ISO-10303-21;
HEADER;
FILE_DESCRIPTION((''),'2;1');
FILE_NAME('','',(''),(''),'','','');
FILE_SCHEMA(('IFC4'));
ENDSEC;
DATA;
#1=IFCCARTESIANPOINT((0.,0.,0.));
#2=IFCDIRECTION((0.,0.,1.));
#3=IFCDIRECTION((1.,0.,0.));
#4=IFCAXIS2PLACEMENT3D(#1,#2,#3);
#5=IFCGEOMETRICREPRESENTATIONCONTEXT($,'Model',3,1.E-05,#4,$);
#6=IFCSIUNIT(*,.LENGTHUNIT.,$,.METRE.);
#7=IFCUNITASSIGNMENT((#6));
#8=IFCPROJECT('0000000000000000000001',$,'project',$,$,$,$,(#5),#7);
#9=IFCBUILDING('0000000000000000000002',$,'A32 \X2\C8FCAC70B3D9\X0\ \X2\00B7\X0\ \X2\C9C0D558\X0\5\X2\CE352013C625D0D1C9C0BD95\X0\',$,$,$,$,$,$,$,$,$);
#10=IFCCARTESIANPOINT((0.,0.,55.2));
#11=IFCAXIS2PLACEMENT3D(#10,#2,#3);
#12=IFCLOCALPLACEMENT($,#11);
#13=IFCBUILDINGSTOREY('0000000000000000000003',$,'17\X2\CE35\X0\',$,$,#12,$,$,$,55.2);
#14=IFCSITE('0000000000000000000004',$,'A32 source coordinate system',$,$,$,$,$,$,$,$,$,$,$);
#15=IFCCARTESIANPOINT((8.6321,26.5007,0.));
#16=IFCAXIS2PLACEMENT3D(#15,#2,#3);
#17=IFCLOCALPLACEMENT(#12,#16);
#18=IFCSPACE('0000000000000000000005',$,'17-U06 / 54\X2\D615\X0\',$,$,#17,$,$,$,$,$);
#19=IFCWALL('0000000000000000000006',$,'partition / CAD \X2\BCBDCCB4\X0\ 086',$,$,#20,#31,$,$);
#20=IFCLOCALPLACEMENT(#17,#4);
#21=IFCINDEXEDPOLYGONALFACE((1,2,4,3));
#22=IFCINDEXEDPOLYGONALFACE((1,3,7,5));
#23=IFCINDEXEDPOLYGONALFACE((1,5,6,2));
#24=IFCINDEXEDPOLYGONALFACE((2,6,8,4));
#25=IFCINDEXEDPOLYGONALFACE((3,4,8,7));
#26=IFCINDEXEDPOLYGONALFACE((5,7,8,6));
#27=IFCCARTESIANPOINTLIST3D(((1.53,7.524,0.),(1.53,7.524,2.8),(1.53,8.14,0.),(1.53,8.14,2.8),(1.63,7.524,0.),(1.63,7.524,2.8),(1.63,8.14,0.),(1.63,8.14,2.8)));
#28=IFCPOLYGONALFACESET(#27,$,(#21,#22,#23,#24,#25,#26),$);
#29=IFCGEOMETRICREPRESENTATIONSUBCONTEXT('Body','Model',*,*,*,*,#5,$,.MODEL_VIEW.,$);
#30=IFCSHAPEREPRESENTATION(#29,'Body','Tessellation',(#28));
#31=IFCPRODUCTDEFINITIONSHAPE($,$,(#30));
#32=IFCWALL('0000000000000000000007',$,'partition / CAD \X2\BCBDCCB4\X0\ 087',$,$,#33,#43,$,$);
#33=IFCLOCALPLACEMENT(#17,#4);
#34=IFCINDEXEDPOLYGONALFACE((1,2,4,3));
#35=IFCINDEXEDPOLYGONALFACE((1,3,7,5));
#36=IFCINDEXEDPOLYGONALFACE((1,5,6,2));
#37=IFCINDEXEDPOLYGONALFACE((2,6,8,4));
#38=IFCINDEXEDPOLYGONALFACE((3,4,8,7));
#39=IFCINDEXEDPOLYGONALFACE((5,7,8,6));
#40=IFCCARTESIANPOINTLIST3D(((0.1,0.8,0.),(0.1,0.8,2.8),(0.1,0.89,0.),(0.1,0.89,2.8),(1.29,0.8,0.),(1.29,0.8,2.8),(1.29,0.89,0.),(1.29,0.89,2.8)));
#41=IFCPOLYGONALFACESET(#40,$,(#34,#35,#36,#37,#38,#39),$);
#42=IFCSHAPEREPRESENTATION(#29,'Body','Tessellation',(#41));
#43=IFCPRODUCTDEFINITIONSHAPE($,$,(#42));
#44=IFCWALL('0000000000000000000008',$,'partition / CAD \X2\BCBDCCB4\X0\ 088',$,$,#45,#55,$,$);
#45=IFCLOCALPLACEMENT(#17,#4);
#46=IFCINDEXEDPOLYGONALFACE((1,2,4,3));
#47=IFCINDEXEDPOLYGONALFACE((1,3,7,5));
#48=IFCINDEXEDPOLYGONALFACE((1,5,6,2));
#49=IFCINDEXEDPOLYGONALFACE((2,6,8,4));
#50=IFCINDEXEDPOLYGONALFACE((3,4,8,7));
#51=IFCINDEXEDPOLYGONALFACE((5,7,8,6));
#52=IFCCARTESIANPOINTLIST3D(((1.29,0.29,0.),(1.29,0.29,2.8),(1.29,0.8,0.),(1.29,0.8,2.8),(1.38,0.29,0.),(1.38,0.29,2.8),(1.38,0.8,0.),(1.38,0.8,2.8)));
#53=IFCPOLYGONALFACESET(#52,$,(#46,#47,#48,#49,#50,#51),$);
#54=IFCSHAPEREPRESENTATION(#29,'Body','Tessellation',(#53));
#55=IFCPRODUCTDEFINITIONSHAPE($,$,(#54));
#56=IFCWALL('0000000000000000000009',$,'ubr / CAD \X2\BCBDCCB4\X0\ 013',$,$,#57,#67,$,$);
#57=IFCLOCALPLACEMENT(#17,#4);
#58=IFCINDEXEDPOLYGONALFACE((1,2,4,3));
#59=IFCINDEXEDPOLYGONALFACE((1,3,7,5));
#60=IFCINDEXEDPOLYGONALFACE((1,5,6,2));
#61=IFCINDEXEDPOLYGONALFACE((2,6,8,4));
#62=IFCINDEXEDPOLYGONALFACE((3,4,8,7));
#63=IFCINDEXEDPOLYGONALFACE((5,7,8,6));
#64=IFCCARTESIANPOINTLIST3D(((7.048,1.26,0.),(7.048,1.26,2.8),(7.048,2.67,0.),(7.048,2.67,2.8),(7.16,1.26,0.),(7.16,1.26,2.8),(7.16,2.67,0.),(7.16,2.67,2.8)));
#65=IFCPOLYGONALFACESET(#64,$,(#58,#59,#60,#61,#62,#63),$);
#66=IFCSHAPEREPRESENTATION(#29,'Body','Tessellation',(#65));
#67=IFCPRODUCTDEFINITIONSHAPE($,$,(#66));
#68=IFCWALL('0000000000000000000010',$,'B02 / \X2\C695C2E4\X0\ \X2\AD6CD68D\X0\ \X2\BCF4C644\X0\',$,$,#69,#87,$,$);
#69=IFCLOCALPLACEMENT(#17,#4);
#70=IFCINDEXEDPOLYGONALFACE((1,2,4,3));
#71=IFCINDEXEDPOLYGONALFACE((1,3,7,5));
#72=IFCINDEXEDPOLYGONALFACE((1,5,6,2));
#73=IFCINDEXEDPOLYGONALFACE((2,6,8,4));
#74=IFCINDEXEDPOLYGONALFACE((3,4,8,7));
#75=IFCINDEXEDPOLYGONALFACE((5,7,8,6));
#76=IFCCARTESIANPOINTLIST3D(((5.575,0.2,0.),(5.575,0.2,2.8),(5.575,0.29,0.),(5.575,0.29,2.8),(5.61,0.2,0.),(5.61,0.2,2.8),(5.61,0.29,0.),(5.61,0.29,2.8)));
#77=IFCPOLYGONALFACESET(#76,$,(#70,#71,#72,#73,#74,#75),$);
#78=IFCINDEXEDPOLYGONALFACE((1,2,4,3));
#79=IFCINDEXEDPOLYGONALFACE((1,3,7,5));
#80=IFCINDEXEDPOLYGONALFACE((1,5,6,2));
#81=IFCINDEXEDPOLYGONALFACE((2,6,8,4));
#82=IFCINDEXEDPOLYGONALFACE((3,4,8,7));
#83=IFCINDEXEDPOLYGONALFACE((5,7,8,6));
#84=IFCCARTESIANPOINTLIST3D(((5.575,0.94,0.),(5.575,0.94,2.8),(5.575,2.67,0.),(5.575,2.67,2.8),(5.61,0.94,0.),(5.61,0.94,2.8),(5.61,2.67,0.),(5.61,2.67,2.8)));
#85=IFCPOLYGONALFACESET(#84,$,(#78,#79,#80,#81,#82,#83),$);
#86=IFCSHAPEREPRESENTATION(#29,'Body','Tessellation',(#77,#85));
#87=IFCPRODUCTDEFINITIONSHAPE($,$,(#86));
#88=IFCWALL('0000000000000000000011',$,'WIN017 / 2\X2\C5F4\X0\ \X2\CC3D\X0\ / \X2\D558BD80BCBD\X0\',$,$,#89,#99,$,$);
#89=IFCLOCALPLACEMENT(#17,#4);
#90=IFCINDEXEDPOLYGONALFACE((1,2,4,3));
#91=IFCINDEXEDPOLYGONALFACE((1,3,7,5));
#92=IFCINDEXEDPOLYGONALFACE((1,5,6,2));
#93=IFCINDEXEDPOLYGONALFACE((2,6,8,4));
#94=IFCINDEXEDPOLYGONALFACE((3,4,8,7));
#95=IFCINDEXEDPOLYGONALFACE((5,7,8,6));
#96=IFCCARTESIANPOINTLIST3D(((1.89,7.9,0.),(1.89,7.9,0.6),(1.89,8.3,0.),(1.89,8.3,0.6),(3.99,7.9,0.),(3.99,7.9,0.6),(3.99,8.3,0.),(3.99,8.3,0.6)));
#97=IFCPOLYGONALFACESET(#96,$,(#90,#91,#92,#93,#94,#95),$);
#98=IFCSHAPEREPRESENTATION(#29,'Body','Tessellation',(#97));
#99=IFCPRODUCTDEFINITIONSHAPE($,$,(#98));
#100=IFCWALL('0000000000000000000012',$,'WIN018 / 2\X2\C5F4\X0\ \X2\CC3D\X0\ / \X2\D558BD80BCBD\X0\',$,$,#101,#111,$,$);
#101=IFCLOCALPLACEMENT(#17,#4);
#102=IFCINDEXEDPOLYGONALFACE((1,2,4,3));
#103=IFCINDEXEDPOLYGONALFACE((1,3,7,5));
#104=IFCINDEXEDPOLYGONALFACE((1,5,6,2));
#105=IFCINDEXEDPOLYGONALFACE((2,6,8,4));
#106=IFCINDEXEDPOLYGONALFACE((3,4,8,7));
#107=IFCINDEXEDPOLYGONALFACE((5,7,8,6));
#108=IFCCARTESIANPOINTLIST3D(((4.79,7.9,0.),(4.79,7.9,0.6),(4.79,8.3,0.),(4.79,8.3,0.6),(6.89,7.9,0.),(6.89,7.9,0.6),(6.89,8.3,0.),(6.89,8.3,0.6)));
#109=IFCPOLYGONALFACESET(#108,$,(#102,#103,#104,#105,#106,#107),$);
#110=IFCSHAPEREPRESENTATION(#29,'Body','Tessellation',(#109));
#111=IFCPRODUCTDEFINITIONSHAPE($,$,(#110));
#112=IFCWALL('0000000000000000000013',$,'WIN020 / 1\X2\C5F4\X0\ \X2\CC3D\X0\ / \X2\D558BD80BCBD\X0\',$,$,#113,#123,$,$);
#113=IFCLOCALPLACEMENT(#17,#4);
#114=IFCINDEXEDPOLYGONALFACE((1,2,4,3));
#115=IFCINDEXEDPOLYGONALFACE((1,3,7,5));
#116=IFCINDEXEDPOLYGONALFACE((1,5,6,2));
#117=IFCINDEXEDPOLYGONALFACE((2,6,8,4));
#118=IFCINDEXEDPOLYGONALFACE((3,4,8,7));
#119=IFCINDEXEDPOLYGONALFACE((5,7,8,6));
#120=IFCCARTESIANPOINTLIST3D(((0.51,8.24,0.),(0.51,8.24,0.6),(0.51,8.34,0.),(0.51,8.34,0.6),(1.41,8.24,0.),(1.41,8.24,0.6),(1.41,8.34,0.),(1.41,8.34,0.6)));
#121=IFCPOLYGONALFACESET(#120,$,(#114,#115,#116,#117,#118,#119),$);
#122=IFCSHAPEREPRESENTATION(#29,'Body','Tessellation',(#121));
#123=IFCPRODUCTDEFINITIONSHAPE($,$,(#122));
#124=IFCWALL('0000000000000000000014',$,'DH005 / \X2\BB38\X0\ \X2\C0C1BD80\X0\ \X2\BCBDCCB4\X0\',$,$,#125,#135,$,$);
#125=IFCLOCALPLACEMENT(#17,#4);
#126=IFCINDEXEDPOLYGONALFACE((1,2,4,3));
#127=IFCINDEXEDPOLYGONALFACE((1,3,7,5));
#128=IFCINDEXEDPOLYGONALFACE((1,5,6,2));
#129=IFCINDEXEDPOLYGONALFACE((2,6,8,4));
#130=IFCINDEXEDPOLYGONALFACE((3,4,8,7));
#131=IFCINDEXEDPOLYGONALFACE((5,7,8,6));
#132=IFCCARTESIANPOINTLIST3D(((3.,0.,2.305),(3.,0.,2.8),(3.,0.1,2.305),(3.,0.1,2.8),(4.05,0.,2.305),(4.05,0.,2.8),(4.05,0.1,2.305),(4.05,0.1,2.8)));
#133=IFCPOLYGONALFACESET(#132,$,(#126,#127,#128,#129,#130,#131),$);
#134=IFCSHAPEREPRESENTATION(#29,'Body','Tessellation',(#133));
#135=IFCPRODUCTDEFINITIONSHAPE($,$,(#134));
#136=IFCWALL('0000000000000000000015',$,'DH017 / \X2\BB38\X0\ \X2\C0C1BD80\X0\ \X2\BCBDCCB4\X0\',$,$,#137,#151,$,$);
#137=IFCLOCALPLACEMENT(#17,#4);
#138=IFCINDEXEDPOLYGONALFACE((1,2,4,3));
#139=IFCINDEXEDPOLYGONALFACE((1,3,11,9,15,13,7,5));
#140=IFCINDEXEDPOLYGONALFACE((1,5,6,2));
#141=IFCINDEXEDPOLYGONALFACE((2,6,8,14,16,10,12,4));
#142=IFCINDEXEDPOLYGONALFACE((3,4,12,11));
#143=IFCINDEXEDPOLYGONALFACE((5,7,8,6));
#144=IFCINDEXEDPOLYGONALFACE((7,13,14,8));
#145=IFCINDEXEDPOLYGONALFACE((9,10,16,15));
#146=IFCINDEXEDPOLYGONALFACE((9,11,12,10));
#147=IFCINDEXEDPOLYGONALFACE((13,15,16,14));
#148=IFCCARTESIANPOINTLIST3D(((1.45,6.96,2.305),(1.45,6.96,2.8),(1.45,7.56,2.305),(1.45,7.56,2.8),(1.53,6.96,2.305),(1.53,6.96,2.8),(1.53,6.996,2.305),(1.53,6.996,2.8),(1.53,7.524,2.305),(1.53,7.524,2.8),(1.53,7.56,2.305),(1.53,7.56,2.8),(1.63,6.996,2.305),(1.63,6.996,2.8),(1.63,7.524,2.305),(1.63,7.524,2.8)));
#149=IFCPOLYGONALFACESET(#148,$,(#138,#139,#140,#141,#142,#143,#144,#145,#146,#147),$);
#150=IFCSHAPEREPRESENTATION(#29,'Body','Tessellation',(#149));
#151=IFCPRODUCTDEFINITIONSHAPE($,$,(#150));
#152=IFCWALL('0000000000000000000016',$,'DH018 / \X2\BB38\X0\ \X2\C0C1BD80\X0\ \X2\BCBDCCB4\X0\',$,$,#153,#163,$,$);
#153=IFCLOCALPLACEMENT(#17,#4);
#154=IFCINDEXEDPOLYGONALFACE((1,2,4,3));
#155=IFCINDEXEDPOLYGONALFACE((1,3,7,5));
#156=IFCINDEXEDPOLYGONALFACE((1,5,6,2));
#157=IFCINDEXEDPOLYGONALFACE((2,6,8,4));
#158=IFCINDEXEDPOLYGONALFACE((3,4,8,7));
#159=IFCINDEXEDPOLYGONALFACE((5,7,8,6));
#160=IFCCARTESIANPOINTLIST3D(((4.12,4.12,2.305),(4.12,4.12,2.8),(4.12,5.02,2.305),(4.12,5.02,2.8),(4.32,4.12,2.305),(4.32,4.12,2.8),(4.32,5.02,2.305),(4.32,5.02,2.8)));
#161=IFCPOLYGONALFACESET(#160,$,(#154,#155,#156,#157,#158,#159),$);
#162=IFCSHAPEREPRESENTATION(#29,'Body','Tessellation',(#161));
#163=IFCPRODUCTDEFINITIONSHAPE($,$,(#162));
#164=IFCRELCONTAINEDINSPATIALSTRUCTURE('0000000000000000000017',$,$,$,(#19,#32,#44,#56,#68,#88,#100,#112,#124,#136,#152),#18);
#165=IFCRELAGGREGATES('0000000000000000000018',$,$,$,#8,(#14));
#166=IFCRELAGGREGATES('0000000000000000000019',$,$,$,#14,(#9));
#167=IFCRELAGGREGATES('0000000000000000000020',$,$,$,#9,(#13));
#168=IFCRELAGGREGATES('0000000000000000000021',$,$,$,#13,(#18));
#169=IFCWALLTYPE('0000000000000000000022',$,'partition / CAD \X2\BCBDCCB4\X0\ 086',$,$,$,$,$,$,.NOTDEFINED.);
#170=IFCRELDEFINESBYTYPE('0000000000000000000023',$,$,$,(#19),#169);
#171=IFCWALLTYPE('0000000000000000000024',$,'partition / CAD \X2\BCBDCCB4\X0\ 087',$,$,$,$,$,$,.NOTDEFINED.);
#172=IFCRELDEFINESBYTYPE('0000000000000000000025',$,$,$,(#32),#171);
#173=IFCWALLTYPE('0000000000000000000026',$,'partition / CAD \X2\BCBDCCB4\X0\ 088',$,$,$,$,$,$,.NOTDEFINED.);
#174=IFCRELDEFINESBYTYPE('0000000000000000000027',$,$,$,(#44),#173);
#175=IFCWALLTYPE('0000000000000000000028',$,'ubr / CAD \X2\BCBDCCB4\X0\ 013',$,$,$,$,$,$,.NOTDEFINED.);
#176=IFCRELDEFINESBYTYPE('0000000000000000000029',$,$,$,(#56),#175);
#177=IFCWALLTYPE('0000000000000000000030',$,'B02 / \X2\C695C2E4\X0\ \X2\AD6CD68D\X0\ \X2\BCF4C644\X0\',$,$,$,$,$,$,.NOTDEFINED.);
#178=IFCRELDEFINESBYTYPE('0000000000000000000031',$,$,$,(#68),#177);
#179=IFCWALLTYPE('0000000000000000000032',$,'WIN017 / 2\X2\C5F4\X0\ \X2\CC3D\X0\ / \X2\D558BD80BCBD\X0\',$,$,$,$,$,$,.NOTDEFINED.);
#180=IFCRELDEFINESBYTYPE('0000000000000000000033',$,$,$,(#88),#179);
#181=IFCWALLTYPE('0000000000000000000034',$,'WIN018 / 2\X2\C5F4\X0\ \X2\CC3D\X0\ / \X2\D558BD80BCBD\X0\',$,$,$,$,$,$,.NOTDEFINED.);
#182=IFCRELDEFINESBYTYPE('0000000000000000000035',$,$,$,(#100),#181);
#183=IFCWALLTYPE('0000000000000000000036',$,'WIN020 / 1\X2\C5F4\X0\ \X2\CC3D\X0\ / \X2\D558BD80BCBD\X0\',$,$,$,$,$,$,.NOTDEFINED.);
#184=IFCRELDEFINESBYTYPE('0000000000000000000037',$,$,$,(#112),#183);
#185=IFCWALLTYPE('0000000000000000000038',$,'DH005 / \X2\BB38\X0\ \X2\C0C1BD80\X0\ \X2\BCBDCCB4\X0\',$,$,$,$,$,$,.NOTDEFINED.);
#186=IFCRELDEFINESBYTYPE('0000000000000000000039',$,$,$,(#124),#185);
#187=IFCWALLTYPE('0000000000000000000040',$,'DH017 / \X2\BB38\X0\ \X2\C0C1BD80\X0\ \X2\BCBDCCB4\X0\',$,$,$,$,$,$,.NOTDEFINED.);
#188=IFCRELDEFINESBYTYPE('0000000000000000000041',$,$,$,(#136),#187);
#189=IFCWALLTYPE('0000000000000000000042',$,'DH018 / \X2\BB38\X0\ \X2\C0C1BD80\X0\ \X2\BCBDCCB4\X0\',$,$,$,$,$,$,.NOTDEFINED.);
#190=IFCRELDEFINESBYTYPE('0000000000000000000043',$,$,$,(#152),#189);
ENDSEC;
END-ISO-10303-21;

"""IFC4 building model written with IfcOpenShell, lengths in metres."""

from ifc_helpers import new_model, si_unit, frame, origin, origin_with_axes, place, context, subcontext, project, spatial, polyline, outline, extrude, source, transform, mapped, type_object, type_shapes, element, save


model = new_model("IFC4")

# Units and contexts
model_context = context("Model", 3, precision=1e-05, world=origin_with_axes())
body_context = subcontext(model_context, "Body", "Model", "MODEL_VIEW")
ifc_project = project(units=[si_unit("LENGTHUNIT", "METRE")], contexts=[model_context])

# Site, building, storey, space
site = spatial("IfcSite", under=ifc_project, Name="A32 source coordinate system")
building = spatial("IfcBuilding", under=site, Name="A32 주거동 · 지하5층–옥탑지붕")
storey_placement = place(None, frame((0.0, 0.0, 55.2), z_axis=(0.0, 0.0, 1.0), x_axis=(1.0, 0.0, 0.0)))
storey = spatial("IfcBuildingStorey", under=building, at=storey_placement, Name="17층", Elevation=55.2)
space_placement = place(storey_placement, frame((8.6321, 26.5007, 0.0), z_axis=(0.0, 0.0, 1.0), x_axis=(1.0, 0.0, 0.0)))
space = spatial("IfcSpace", under=storey, at=space_placement, Name="17-U06 / 54형")

# Walls
wall_type_1 = type_object("IfcWallType", Name="partition / CAD 벽체 086", PredefinedType="NOTDEFINED")
shared_shape_1 = source(origin(), body_context, "Body", "SweptSolid", [
    extrude(outline(polyline([(1.53, 7.524), (1.53, 8.14), (1.63, 8.14), (1.63, 7.524), (1.53, 7.524)])), origin(), (0.0, 0.0, 1.0), 2.8),
])
type_shapes(wall_type_1, [shared_shape_1])
wall_1_placement = place(space_placement, origin_with_axes())
element("IfcWall", 1, at=wall_1_placement, inside=space, type_object=wall_type_1, Name="partition / CAD 벽체 086", context=body_context, shape_type="MappedRepresentation", body=[
    mapped(shared_shape_1, transform((0.0, 0.0, 0.0), scale=1.0)),
])
wall_type_2 = type_object("IfcWallType", Name="partition / CAD 벽체 087", PredefinedType="NOTDEFINED")
shared_shape_2 = source(origin(), body_context, "Body", "SweptSolid", [
    extrude(outline(polyline([(1.29, 0.8), (0.1, 0.8), (0.1, 0.89), (1.29, 0.89), (1.29, 0.8)])), origin(), (0.0, 0.0, 1.0), 2.8),
])
type_shapes(wall_type_2, [shared_shape_2])
wall_2_placement = place(space_placement, origin_with_axes())
element("IfcWall", 2, at=wall_2_placement, inside=space, type_object=wall_type_2, Name="partition / CAD 벽체 087", context=body_context, shape_type="MappedRepresentation", body=[
    mapped(shared_shape_2, transform((0.0, 0.0, 0.0), scale=1.0)),
])
wall_type_3 = type_object("IfcWallType", Name="partition / CAD 벽체 088", PredefinedType="NOTDEFINED")
shared_shape_3 = source(origin(), body_context, "Body", "SweptSolid", [
    extrude(outline(polyline([(1.29, 0.29), (1.29, 0.8), (1.38, 0.8), (1.38, 0.29), (1.29, 0.29)])), origin(), (0.0, 0.0, 1.0), 2.8),
])
type_shapes(wall_type_3, [shared_shape_3])
wall_3_placement = place(space_placement, origin_with_axes())
element("IfcWall", 3, at=wall_3_placement, inside=space, type_object=wall_type_3, Name="partition / CAD 벽체 088", context=body_context, shape_type="MappedRepresentation", body=[
    mapped(shared_shape_3, transform((0.0, 0.0, 0.0), scale=1.0)),
])
wall_type_4 = type_object("IfcWallType", Name="ubr / CAD 벽체 013", PredefinedType="NOTDEFINED")
shared_shape_4 = source(origin(), body_context, "Body", "SweptSolid", [
    extrude(outline(polyline([(7.16, 1.26), (7.048, 1.26), (7.048, 2.67), (7.16, 2.67), (7.16, 1.26)])), origin(), (0.0, 0.0, 1.0), 2.8),
])
type_shapes(wall_type_4, [shared_shape_4])
wall_4_placement = place(space_placement, origin_with_axes())
element("IfcWall", 4, at=wall_4_placement, inside=space, type_object=wall_type_4, Name="ubr / CAD 벽체 013", context=body_context, shape_type="MappedRepresentation", body=[
    mapped(shared_shape_4, transform((0.0, 0.0, 0.0), scale=1.0)),
])
wall_type_5 = type_object("IfcWallType", Name="B02 / 욕실 구획 보완", PredefinedType="NOTDEFINED")
shared_shape_5 = source(origin(), body_context, "Body", "SweptSolid", [
    extrude(outline(polyline([(5.575, 0.2), (5.575, 0.29), (5.61, 0.29), (5.61, 0.2), (5.575, 0.2)])), origin(), (0.0, 0.0, 1.0), 2.8),
    extrude(outline(polyline([(5.575, 0.94), (5.575, 2.67), (5.61, 2.67), (5.61, 0.94), (5.575, 0.94)])), origin(), (0.0, 0.0, 1.0), 2.8),
])
type_shapes(wall_type_5, [shared_shape_5])
wall_5_placement = place(space_placement, origin_with_axes())
element("IfcWall", 5, at=wall_5_placement, inside=space, type_object=wall_type_5, Name="B02 / 욕실 구획 보완", context=body_context, shape_type="MappedRepresentation", body=[
    mapped(shared_shape_5, transform((0.0, 0.0, 0.0), scale=1.0)),
])
wall_type_6 = type_object("IfcWallType", Name="WIN017 / 2열 창 / 하부벽", PredefinedType="NOTDEFINED")
shared_shape_6 = source(origin(), body_context, "Body", "SweptSolid", [
    extrude(outline(polyline([(3.99, 8.3), (3.99, 7.9), (1.89, 7.9), (1.89, 8.3), (3.99, 8.3)])), origin(), (0.0, 0.0, 1.0), 0.6),
])
type_shapes(wall_type_6, [shared_shape_6])
wall_6_placement = place(space_placement, origin_with_axes())
element("IfcWall", 6, at=wall_6_placement, inside=space, type_object=wall_type_6, Name="WIN017 / 2열 창 / 하부벽", context=body_context, shape_type="MappedRepresentation", body=[
    mapped(shared_shape_6, transform((0.0, 0.0, 0.0), scale=1.0)),
])
wall_type_7 = type_object("IfcWallType", Name="WIN018 / 2열 창 / 하부벽", PredefinedType="NOTDEFINED")
shared_shape_7 = source(origin(), body_context, "Body", "SweptSolid", [
    extrude(outline(polyline([(6.89, 8.3), (6.89, 7.9), (4.79, 7.9), (4.79, 8.3), (6.89, 8.3)])), origin(), (0.0, 0.0, 1.0), 0.6),
])
type_shapes(wall_type_7, [shared_shape_7])
wall_7_placement = place(space_placement, origin_with_axes())
element("IfcWall", 7, at=wall_7_placement, inside=space, type_object=wall_type_7, Name="WIN018 / 2열 창 / 하부벽", context=body_context, shape_type="MappedRepresentation", body=[
    mapped(shared_shape_7, transform((0.0, 0.0, 0.0), scale=1.0)),
])
wall_type_8 = type_object("IfcWallType", Name="WIN020 / 1열 창 / 하부벽", PredefinedType="NOTDEFINED")
shared_shape_8 = source(origin(), body_context, "Body", "SweptSolid", [
    extrude(outline(polyline([(1.41, 8.34), (1.41, 8.24), (0.51, 8.24), (0.51, 8.34), (1.41, 8.34)])), origin(), (0.0, 0.0, 1.0), 0.6),
])
type_shapes(wall_type_8, [shared_shape_8])
wall_8_placement = place(space_placement, origin_with_axes())
element("IfcWall", 8, at=wall_8_placement, inside=space, type_object=wall_type_8, Name="WIN020 / 1열 창 / 하부벽", context=body_context, shape_type="MappedRepresentation", body=[
    mapped(shared_shape_8, transform((0.0, 0.0, 0.0), scale=1.0)),
])
wall_type_9 = type_object("IfcWallType", Name="DH005 / 문 상부 벽체", PredefinedType="NOTDEFINED")
shared_shape_9 = source(origin(), body_context, "Body", "SweptSolid", [
    extrude(outline(polyline([(4.05, 0.0), (3.0, 0.0), (3.0, 0.1), (4.05, 0.1), (4.05, 0.0)])), frame((0.0, 0.0, 2.305)), (0.0, 0.0, 1.0), 0.495),
])
type_shapes(wall_type_9, [shared_shape_9])
wall_9_placement = place(space_placement, origin_with_axes())
element("IfcWall", 9, at=wall_9_placement, inside=space, type_object=wall_type_9, Name="DH005 / 문 상부 벽체", context=body_context, shape_type="MappedRepresentation", body=[
    mapped(shared_shape_9, transform((0.0, 0.0, 0.0), scale=1.0)),
])
wall_type_10 = type_object("IfcWallType", Name="DH017 / 문 상부 벽체", PredefinedType="NOTDEFINED")
shared_shape_10 = source(origin(), body_context, "Body", "SweptSolid", [
    extrude(outline(polyline([(1.63, 7.524), (1.63, 6.996), (1.53, 6.996), (1.53, 6.96), (1.45, 6.96), (1.45, 7.56), (1.53, 7.56), (1.53, 7.524), (1.63, 7.524)])), frame((0.0, 0.0, 2.305)), (0.0, 0.0, 1.0), 0.495),
])
type_shapes(wall_type_10, [shared_shape_10])
wall_10_placement = place(space_placement, origin_with_axes())
element("IfcWall", 10, at=wall_10_placement, inside=space, type_object=wall_type_10, Name="DH017 / 문 상부 벽체", context=body_context, shape_type="MappedRepresentation", body=[
    mapped(shared_shape_10, transform((0.0, 0.0, 0.0), scale=1.0)),
])
wall_type_11 = type_object("IfcWallType", Name="DH018 / 문 상부 벽체", PredefinedType="NOTDEFINED")
shared_shape_11 = source(origin(), body_context, "Body", "SweptSolid", [
    extrude(outline(polyline([(4.32, 4.12), (4.12, 4.12), (4.12, 5.02), (4.32, 5.02), (4.32, 4.12)])), frame((0.0, 0.0, 2.305)), (0.0, 0.0, 1.0), 0.495),
])
type_shapes(wall_type_11, [shared_shape_11])
wall_11_placement = place(space_placement, origin_with_axes())
element("IfcWall", 11, at=wall_11_placement, inside=space, type_object=wall_type_11, Name="DH018 / 문 상부 벽체", context=body_context, shape_type="MappedRepresentation", body=[
    mapped(shared_shape_11, transform((0.0, 0.0, 0.0), scale=1.0)),
])

save(model, "model.ifc")
